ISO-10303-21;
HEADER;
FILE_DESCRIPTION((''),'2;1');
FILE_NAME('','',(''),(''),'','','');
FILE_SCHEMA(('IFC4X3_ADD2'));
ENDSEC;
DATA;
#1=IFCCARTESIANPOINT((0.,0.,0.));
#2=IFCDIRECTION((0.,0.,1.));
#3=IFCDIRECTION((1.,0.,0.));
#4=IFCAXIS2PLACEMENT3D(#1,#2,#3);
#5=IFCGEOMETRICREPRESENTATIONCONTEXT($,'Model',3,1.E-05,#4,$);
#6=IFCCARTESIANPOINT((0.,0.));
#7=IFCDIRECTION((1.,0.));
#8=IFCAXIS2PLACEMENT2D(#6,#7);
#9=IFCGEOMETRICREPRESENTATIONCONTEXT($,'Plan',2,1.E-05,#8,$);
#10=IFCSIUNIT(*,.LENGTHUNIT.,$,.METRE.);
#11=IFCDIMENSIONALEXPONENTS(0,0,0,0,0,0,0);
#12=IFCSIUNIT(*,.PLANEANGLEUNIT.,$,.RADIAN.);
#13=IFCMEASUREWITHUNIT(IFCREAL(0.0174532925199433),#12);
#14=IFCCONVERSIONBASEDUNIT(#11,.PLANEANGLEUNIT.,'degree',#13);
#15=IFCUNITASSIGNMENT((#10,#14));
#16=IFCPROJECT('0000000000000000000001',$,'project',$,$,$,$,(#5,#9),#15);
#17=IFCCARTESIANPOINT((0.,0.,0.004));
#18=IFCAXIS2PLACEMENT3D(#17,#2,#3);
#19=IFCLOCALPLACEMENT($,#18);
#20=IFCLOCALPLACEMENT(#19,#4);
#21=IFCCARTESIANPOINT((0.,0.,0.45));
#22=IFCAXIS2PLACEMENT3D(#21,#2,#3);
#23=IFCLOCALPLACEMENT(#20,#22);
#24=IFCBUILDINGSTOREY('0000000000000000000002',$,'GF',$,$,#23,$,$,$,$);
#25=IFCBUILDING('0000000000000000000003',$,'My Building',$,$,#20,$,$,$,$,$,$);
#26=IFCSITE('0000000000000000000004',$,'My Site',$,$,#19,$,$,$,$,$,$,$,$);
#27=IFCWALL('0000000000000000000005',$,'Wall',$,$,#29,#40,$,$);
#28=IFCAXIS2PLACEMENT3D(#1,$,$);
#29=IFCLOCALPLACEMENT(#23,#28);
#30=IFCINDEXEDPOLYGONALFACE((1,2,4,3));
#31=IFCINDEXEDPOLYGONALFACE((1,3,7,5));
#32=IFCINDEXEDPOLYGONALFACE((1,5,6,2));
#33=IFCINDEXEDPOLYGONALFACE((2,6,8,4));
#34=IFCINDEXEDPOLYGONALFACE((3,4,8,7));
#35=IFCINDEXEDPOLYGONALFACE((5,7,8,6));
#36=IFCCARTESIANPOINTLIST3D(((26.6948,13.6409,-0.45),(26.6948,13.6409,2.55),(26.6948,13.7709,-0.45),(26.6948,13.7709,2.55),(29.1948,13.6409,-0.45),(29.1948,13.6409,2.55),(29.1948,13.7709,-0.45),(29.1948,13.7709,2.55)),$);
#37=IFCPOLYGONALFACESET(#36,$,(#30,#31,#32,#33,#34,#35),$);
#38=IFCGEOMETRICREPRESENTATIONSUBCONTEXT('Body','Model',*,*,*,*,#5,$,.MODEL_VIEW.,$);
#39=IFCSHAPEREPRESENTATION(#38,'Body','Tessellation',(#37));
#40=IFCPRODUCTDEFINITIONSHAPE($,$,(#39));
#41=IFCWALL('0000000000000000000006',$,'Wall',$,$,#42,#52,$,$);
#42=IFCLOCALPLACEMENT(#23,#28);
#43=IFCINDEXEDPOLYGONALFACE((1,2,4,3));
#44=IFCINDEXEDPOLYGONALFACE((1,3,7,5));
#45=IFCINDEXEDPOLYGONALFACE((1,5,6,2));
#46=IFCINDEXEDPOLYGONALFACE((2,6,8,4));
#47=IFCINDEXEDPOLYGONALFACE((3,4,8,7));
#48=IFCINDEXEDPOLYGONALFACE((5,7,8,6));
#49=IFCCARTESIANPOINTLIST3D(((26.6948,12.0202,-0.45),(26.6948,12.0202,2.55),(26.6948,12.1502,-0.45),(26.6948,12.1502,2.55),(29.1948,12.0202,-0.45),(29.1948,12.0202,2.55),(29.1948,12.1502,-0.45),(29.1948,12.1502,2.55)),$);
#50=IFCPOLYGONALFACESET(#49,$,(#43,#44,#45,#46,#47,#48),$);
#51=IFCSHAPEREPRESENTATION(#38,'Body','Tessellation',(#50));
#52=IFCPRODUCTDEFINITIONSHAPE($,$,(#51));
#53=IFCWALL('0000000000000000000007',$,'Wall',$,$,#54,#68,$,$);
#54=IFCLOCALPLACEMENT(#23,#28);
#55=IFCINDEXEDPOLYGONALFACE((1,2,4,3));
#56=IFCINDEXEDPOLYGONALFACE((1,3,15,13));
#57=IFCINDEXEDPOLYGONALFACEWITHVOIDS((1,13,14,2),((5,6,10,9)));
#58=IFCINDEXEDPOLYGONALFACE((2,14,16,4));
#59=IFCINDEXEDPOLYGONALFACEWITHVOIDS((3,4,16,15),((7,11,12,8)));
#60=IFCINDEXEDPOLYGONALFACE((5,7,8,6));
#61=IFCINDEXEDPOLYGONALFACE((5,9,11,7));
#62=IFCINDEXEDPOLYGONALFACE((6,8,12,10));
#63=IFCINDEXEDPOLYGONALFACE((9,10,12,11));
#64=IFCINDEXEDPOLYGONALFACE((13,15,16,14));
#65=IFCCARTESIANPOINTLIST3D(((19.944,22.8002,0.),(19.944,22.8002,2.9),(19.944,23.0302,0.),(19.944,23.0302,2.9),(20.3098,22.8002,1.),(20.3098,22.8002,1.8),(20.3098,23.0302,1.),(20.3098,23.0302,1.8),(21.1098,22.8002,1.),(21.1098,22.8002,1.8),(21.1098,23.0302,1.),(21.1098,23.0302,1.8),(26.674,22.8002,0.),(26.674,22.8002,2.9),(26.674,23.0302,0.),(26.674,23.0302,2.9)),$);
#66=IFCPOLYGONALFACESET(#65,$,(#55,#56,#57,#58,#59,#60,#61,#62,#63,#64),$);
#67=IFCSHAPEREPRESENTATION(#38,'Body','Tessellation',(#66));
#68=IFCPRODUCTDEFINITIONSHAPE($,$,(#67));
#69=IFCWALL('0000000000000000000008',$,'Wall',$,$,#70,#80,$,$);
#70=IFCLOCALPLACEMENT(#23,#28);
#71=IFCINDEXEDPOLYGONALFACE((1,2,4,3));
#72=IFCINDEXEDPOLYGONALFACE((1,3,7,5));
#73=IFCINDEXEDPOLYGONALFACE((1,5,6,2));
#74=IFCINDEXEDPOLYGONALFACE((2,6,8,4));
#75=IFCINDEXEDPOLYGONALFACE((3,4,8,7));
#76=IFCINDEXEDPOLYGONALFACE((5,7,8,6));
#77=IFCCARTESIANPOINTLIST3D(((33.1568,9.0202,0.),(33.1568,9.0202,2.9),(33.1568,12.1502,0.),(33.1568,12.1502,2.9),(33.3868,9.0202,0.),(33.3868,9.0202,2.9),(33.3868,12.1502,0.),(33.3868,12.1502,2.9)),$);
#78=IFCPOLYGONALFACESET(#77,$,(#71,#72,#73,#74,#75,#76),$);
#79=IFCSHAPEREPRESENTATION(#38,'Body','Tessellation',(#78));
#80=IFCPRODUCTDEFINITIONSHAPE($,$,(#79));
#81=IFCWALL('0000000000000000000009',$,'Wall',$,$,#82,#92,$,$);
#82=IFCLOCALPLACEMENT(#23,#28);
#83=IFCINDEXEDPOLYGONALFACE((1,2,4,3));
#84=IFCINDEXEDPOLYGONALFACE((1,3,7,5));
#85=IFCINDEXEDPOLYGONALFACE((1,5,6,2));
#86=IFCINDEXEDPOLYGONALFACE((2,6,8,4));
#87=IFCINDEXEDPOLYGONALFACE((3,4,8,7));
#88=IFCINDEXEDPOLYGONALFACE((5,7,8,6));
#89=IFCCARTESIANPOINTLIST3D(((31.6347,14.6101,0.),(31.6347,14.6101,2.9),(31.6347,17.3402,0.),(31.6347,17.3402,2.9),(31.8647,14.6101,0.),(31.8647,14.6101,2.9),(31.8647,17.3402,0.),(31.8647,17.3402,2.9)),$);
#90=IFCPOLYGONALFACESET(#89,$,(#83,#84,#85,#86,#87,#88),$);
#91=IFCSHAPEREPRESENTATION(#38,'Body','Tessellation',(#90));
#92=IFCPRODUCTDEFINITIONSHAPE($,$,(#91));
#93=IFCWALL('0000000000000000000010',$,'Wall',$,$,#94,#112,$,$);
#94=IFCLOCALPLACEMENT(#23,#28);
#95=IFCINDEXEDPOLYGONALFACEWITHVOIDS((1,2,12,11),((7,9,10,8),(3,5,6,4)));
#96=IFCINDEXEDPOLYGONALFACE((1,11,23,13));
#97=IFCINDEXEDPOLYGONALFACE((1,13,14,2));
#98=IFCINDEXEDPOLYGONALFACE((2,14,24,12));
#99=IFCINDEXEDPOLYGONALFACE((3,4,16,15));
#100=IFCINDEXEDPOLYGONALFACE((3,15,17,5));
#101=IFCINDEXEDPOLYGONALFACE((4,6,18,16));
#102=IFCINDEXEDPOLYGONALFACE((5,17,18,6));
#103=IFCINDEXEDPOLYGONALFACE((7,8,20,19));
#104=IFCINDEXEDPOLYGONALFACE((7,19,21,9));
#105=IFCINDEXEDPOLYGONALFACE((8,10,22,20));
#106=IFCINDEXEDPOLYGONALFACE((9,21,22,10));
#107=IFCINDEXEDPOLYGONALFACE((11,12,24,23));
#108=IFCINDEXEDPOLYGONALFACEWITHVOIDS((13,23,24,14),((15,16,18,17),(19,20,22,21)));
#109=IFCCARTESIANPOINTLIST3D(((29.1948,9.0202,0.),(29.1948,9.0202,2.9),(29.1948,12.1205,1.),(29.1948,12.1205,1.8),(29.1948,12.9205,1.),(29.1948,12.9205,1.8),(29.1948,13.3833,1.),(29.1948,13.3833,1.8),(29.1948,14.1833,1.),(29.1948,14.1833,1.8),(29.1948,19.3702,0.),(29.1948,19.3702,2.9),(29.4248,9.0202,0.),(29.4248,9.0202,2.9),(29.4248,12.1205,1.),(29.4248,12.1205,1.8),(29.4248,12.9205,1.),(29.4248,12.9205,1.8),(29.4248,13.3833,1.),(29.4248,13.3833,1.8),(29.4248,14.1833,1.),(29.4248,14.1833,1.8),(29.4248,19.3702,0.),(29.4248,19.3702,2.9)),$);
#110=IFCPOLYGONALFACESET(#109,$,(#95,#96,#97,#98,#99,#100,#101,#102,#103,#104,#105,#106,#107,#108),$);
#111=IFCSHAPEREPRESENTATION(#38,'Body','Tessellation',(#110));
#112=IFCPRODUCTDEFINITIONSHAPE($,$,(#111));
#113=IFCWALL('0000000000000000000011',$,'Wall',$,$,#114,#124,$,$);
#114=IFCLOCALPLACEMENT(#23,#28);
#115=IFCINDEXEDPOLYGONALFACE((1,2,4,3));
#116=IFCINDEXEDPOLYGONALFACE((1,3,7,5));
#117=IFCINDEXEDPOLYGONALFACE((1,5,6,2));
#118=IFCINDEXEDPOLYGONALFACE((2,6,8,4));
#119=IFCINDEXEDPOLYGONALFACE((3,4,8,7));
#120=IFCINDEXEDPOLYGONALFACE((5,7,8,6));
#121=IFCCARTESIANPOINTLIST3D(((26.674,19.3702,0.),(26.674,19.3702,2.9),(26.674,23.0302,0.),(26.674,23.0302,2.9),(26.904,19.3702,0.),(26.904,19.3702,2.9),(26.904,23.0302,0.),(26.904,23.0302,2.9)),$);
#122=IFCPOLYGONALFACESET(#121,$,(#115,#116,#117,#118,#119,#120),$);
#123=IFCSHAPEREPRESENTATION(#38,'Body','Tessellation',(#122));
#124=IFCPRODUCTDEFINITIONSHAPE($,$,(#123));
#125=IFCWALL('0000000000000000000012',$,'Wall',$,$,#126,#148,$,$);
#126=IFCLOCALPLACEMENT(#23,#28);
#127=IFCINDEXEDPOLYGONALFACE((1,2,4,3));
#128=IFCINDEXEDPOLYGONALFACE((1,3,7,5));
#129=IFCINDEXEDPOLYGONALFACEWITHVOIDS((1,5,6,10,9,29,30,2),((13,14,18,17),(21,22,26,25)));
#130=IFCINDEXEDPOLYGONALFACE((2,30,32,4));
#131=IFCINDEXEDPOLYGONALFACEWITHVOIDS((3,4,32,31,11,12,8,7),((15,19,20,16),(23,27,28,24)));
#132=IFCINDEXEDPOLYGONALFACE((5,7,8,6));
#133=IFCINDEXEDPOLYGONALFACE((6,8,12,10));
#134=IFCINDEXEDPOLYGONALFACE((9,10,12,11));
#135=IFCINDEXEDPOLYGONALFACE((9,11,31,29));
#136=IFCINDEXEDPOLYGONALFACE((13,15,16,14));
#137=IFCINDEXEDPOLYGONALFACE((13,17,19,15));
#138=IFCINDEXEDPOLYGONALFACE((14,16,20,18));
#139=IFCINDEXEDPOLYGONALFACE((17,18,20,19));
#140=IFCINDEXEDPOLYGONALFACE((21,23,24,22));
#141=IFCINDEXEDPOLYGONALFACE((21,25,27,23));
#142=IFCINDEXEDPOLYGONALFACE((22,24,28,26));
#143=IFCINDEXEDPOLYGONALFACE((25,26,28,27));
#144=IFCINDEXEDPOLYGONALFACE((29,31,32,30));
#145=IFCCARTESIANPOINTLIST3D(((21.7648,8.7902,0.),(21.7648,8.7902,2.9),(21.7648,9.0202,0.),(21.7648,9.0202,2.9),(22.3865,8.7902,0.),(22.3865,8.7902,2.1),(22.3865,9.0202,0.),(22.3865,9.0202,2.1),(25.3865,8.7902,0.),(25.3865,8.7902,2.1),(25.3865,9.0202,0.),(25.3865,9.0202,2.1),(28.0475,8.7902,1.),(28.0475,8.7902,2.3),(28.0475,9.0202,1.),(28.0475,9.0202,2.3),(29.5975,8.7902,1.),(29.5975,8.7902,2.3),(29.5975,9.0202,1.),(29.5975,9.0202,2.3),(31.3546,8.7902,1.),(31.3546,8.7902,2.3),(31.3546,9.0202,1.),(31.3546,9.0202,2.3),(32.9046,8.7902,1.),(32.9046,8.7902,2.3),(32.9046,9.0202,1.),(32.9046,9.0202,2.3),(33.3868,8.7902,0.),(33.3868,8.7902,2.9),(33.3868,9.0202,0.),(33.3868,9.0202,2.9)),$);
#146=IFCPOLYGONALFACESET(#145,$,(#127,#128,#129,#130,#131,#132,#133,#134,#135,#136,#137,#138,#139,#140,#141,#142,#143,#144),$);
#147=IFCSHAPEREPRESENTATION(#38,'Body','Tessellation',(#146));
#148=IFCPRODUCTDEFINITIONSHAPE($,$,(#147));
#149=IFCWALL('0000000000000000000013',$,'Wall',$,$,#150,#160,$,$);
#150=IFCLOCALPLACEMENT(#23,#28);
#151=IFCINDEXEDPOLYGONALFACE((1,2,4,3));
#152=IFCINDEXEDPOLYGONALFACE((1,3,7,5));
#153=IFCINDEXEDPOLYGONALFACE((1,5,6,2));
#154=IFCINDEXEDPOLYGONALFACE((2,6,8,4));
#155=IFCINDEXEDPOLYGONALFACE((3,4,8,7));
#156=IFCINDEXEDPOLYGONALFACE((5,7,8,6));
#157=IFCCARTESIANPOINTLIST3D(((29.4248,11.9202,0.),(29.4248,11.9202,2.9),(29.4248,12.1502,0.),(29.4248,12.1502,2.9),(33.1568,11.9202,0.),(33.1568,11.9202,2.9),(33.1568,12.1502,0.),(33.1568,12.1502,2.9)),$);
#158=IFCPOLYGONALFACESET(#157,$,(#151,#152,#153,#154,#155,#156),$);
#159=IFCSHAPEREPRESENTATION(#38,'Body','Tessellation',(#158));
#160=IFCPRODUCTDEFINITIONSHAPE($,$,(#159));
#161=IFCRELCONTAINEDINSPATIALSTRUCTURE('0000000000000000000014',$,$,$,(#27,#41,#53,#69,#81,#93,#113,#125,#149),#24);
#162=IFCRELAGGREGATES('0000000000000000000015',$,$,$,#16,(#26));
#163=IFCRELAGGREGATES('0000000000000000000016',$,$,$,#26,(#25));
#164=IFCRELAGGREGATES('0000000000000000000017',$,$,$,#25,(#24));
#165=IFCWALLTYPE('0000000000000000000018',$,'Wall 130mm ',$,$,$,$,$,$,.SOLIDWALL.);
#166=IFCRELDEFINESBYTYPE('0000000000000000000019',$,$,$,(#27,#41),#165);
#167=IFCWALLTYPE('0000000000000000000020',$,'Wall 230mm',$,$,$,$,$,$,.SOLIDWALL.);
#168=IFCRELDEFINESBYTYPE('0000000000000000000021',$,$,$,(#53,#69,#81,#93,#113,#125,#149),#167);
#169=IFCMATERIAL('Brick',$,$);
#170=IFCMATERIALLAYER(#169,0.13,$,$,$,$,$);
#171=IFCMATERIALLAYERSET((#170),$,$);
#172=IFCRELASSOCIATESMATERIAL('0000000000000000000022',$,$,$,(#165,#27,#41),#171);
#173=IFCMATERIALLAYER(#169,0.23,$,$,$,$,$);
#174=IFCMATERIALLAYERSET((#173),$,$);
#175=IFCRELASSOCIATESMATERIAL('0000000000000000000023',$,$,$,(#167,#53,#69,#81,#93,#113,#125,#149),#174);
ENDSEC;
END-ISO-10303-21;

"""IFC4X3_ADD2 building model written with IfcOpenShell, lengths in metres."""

from ifc_helpers import new_model, entity, si_unit, converted_unit, frame, origin_with_axes, origin_2d_with_axis, place, context, subcontext, project, spatial, line, indexed_curve, outline, extrude, source, transform, mapped, material, layer, layer_set, layer_usage, type_object, element, save


model = new_model("IFC4X3_ADD2")

# Units and contexts
model_context = context("Model", 3, precision=1e-05, world=origin_with_axes())
plan_context = context("Plan", 2, precision=1e-05, world=origin_2d_with_axis())
body_context_1 = subcontext(model_context, "Body", "Model", "MODEL_VIEW")
ifc_project = project(units=[si_unit("LENGTHUNIT", "METRE"), converted_unit("PLANEANGLEUNIT", "degree", entity("IfcReal", 0.0174532925199433), si_unit("PLANEANGLEUNIT", "RADIAN"), dimensions=[0, 0, 0, 0, 0, 0, 0])], contexts=[model_context, plan_context])

# Site, building, storey
site_placement = place(None, frame((0.0, 0.0, 0.004), z_axis=(0.0, 0.0, 1.0), x_axis=(1.0, 0.0, 0.0)))
site = spatial("IfcSite", under=ifc_project, at=site_placement, Name="My Site")
building_placement = place(site_placement, origin_with_axes())
building = spatial("IfcBuilding", under=site, at=building_placement, Name="My Building")
storey_placement = place(building_placement, frame((0.0, 0.0, 0.45), z_axis=(0.0, 0.0, 1.0), x_axis=(1.0, 0.0, 0.0)))
storey = spatial("IfcBuildingStorey", under=building, at=storey_placement, Name="GF")

# Walls
ifc_material = material(Name="Brick")
ifc_layer_1 = layer(ifc_material, 0.13)
ifc_layer_set_1 = layer_set([ifc_layer_1])
ifc_layer_usage_1 = layer_usage(ifc_layer_set_1, "AXIS2", "POSITIVE", 0.0)
wall_type_1 = type_object("IfcWallType", Name="Wall 130mm ", PredefinedType="SOLIDWALL", material=ifc_layer_set_1)
wall_1_placement = place(storey_placement, frame((29.1948, 13.7709, -0.45), z_axis=(0.0, 0.0, 1.0), x_axis=(-1.0, 0.0, 0.0)))
element("IfcWall", 1, at=wall_1_placement, inside=storey, type_object=wall_type_1, material=ifc_layer_usage_1, Name="Wall", context=body_context_1, shape_type="SweptSolid", body=[
    extrude(outline(indexed_curve([(0.0, 0.0), (0.0, 0.13), (2.5, 0.13), (2.5, 0.0), (0.0, 0.0)], self_intersect=False)), origin_with_axes(), (0.0, 0.0, 1.0), 3.0),
])
ifc_layer_usage_2 = layer_usage(ifc_layer_set_1, "AXIS2", "POSITIVE", 0.0)
wall_2_placement = place(storey_placement, frame((29.1948, 12.1502, -0.45), z_axis=(0.0, 0.0, 1.0), x_axis=(-1.0, 0.0, 0.0)))
element("IfcWall", 2, at=wall_2_placement, inside=storey, type_object=wall_type_1, material=ifc_layer_usage_2, Name="Wall", context=body_context_1, shape_type="SweptSolid", body=[
    extrude(outline(indexed_curve([(0.0, 0.0), (0.0, 0.13), (2.5, 0.13), (2.5, 0.0), (0.0, 0.0)], self_intersect=False)), origin_with_axes(), (0.0, 0.0, 1.0), 3.0),
])

# Wall, opening
ifc_layer_2 = layer(ifc_material, 0.23)
ifc_layer_set_2 = layer_set([ifc_layer_2])
ifc_layer_usage_3 = layer_usage(ifc_layer_set_2, "AXIS2", "POSITIVE", 0.0)
wall_type_2 = type_object("IfcWallType", Name="Wall 230mm", PredefinedType="SOLIDWALL", material=ifc_layer_set_2)
wall_3_placement = place(storey_placement, frame((26.674, 23.0302, 0.0), z_axis=(0.0, 0.0, 1.0), x_axis=(-1.0, 0.0, 0.0)))
wall_3 = element("IfcWall", 3, at=wall_3_placement, inside=storey, type_object=wall_type_2, material=ifc_layer_usage_3, Name="Wall", context=body_context_1, shape_type="SweptSolid", body=[
    extrude(outline(indexed_curve([(0.0, 0.0), (0.0, 0.23), (6.73, 0.23), (6.73, 0.0), (0.0, 0.0)], self_intersect=False)), origin_with_axes(), (0.0, 0.0, 1.0), 2.9),
])
shared_shape_1 = source(origin_with_axes(), body_context_1, "Body", "SweptSolid", [
    extrude(outline(indexed_curve([(0.0, 0.0), (0.8, 0.0), (0.8, 0.8), (0.0, 0.8)], segments=[line(1, 2, 3, 4, 1)])), frame((-0.4, -0.6, 0.0), z_axis=(0.0, -1.0, 0.0), x_axis=(1.0, 0.0, 0.0)), (0.0, 0.0, -1.0), 1.2),
])
opening_1_placement = place(wall_3_placement, frame((5.9642, 0.0, 1.0), z_axis=(0.0, 0.0, 1.0), x_axis=(1.0, 0.0, 0.0)))
element("IfcOpeningElement", 4, at=opening_1_placement, cuts=wall_3, PredefinedType="OPENING", context=body_context_1, shape_type="MappedRepresentation", body=[
    mapped(shared_shape_1, transform((0.0, 0.0, 0.0), x_axis=(1.0, 0.0, 0.0), y_axis=(0.0, 1.0, 0.0), z_axis=(0.0, 0.0, 1.0), scale=1.0)),
])

# Walls
ifc_layer_usage_4 = layer_usage(ifc_layer_set_2, "AXIS2", "POSITIVE", 0.0)
wall_4_placement = place(storey_placement, frame((33.3868, 9.0202, 0.0), z_axis=(0.0, 0.0, 1.0), x_axis=(0.000001, 1.0, 0.0)))
element("IfcWall", 5, at=wall_4_placement, inside=storey, type_object=wall_type_2, material=ifc_layer_usage_4, Name="Wall", context=body_context_1, shape_type="SweptSolid", body=[
    extrude(outline(indexed_curve([(0.0, 0.0), (0.0, 0.23), (3.13, 0.23), (3.13, 0.0), (0.0, 0.0)], self_intersect=False)), origin_with_axes(), (0.0, 0.0, 1.0), 2.9),
])
ifc_layer_usage_5 = layer_usage(ifc_layer_set_2, "AXIS2", "POSITIVE", 0.0)
wall_5_placement = place(storey_placement, frame((31.8647, 14.6101, 0.0), z_axis=(0.0, 0.0, 1.0), x_axis=(0.000001, 1.0, 0.0)))
element("IfcWall", 6, at=wall_5_placement, inside=storey, type_object=wall_type_2, material=ifc_layer_usage_5, Name="Wall", context=body_context_1, shape_type="SweptSolid", body=[
    extrude(outline(indexed_curve([(0.0, 0.0), (0.0, 0.23), (2.73, 0.23), (2.73, 0.0), (0.0, 0.0)], self_intersect=False)), origin_with_axes(), (0.0, 0.0, 1.0), 2.9),
])

# Wall, openings
ifc_layer_usage_6 = layer_usage(ifc_layer_set_2, "AXIS2", "POSITIVE", 0.0)
wall_6_placement = place(storey_placement, frame((29.4248, 9.0202, 0.0), z_axis=(0.0, 0.0, 1.0), x_axis=(0.000001, 1.0, 0.0)))
wall_6 = element("IfcWall", 7, at=wall_6_placement, inside=storey, type_object=wall_type_2, material=ifc_layer_usage_6, Name="Wall", context=body_context_1, shape_type="SweptSolid", body=[
    extrude(outline(indexed_curve([(0.0, 0.0), (0.0, 0.23), (10.35, 0.23), (10.35, 0.0), (0.0, 0.0)], self_intersect=False)), origin_with_axes(), (0.0, 0.0, 1.0), 2.9),
])
opening_2_placement = place(wall_6_placement, frame((4.7631, 0.0, 1.0), z_axis=(0.0, 0.0, 1.0), x_axis=(1.0, 0.0, 0.0)))
element("IfcOpeningElement", 8, at=opening_2_placement, cuts=wall_6, PredefinedType="OPENING", context=body_context_1, shape_type="MappedRepresentation", body=[
    mapped(shared_shape_1, transform((0.0, 0.0, 0.0), x_axis=(1.0, 0.0, 0.0), y_axis=(0.0, 1.0, 0.0), z_axis=(0.0, 0.0, 1.0), scale=1.0)),
])
opening_3_placement = place(wall_6_placement, frame((3.5003, 0.0, 1.0), z_axis=(0.0, 0.0, 1.0), x_axis=(1.0, 0.0, 0.0)))
element("IfcOpeningElement", 9, at=opening_3_placement, cuts=wall_6, PredefinedType="OPENING", context=body_context_1, shape_type="MappedRepresentation", body=[
    mapped(shared_shape_1, transform((0.0, 0.0, 0.0), x_axis=(1.0, 0.0, 0.0), y_axis=(0.0, 1.0, 0.0), z_axis=(0.0, 0.0, 1.0), scale=1.0)),
])

# Wall
ifc_layer_usage_7 = layer_usage(ifc_layer_set_2, "AXIS2", "POSITIVE", 0.0)
wall_7_placement = place(storey_placement, frame((26.904, 19.3702, 0.0), z_axis=(0.0, 0.0, 1.0), x_axis=(0.000001, 1.0, 0.0)))
element("IfcWall", 10, at=wall_7_placement, inside=storey, type_object=wall_type_2, material=ifc_layer_usage_7, Name="Wall", context=body_context_1, shape_type="SweptSolid", body=[
    extrude(outline(indexed_curve([(0.0, 0.0), (0.0, 0.23), (3.66, 0.23), (3.66, 0.0), (0.0, 0.0)], self_intersect=False)), origin_with_axes(), (0.0, 0.0, 1.0), 2.9),
])

# Wall, openings
ifc_layer_usage_8 = layer_usage(ifc_layer_set_2, "AXIS2", "POSITIVE", 0.0)
wall_8_placement = place(storey_placement, frame((33.3868, 9.0202, 0.0), z_axis=(0.0, 0.0, 1.0), x_axis=(-1.0, 0.0, 0.0)))
wall_8 = element("IfcWall", 11, at=wall_8_placement, inside=storey, type_object=wall_type_2, material=ifc_layer_usage_8, Name="Wall", context=body_context_1, shape_type="SweptSolid", body=[
    extrude(outline(indexed_curve([(0.0, 0.0), (0.0, 0.23), (11.622, 0.23), (11.622, 0.0), (0.0, 0.0)], self_intersect=False)), origin_with_axes(), (0.0, 0.0, 1.0), 2.9),
])
shared_shape_2 = source(origin_with_axes(), body_context_1, "Body", "SweptSolid", [
    extrude(outline(indexed_curve([(0.0, 0.0), (3.0, 0.0), (3.0, 2.1), (0.0, 2.1)], segments=[line(1, 2, 3, 4, 1)])), frame((0.0, -0.6, 0.0), z_axis=(0.0, -1.0, 0.0), x_axis=(1.0, 0.0, 0.0)), (0.0, 0.0, -1.0), 1.2),
])
opening_4_placement = place(wall_8_placement, frame((8.0003, 0.0, 0.0), z_axis=(0.0, 0.0, 1.0), x_axis=(1.0, 0.0, 0.0)))
element("IfcOpeningElement", 12, at=opening_4_placement, cuts=wall_8, PredefinedType="OPENING", context=body_context_1, shape_type="MappedRepresentation", body=[
    mapped(shared_shape_2, transform((0.0, 0.0, 0.0), x_axis=(1.0, 0.0, 0.0), y_axis=(0.0, 1.0, 0.0), z_axis=(0.0, 0.0, 1.0), scale=1.0)),
])
shared_shape_3 = source(origin_with_axes(), body_context_1, "Body", "SweptSolid", [
    extrude(outline(indexed_curve([(0.0, 0.0), (1.55, 0.0), (1.55, 1.3), (0.0, 1.3)], segments=[line(1, 2, 3, 4, 1)])), frame((-0.775, -0.6, 0.0), z_axis=(0.0, -1.0, 0.0), x_axis=(1.0, 0.0, 0.0)), (0.0, 0.0, -1.0), 1.2),
])
opening_5_placement = place(wall_8_placement, frame((1.2571, 0.0, 1.0), z_axis=(0.0, 0.0, 1.0), x_axis=(1.0, 0.0, 0.0)))
element("IfcOpeningElement", 13, at=opening_5_placement, cuts=wall_8, PredefinedType="OPENING", context=body_context_1, shape_type="MappedRepresentation", body=[
    mapped(shared_shape_3, transform((0.0, 0.0, 0.0), x_axis=(1.0, 0.0, 0.0), y_axis=(0.0, 1.0, 0.0), z_axis=(0.0, 0.0, 1.0), scale=1.0)),
])
opening_6_placement = place(wall_8_placement, frame((4.5642, 0.0, 1.0), z_axis=(0.0, 0.0, 1.0), x_axis=(1.0, 0.0, 0.0)))
element("IfcOpeningElement", 14, at=opening_6_placement, cuts=wall_8, PredefinedType="OPENING", context=body_context_1, shape_type="MappedRepresentation", body=[
    mapped(shared_shape_3, transform((0.0, 0.0, 0.0), x_axis=(1.0, 0.0, 0.0), y_axis=(0.0, 1.0, 0.0), z_axis=(0.0, 0.0, 1.0), scale=1.0)),
])

# Wall
ifc_layer_usage_9 = layer_usage(ifc_layer_set_2, "AXIS2", "POSITIVE", 0.0)
wall_9_placement = place(storey_placement, frame((33.1568, 12.1502, 0.0), z_axis=(0.0, 0.0, 1.0), x_axis=(-1.0, 0.0, 0.0)))
element("IfcWall", 15, at=wall_9_placement, inside=storey, type_object=wall_type_2, material=ifc_layer_usage_9, Name="Wall", context=body_context_1, shape_type="SweptSolid", body=[
    extrude(outline(indexed_curve([(0.0, 0.0), (0.0, 0.23), (3.732, 0.23), (3.732, 0.0), (0.0, 0.0)], self_intersect=False)), origin_with_axes(), (0.0, 0.0, 1.0), 2.9),
])

save(model, "model.ifc")
